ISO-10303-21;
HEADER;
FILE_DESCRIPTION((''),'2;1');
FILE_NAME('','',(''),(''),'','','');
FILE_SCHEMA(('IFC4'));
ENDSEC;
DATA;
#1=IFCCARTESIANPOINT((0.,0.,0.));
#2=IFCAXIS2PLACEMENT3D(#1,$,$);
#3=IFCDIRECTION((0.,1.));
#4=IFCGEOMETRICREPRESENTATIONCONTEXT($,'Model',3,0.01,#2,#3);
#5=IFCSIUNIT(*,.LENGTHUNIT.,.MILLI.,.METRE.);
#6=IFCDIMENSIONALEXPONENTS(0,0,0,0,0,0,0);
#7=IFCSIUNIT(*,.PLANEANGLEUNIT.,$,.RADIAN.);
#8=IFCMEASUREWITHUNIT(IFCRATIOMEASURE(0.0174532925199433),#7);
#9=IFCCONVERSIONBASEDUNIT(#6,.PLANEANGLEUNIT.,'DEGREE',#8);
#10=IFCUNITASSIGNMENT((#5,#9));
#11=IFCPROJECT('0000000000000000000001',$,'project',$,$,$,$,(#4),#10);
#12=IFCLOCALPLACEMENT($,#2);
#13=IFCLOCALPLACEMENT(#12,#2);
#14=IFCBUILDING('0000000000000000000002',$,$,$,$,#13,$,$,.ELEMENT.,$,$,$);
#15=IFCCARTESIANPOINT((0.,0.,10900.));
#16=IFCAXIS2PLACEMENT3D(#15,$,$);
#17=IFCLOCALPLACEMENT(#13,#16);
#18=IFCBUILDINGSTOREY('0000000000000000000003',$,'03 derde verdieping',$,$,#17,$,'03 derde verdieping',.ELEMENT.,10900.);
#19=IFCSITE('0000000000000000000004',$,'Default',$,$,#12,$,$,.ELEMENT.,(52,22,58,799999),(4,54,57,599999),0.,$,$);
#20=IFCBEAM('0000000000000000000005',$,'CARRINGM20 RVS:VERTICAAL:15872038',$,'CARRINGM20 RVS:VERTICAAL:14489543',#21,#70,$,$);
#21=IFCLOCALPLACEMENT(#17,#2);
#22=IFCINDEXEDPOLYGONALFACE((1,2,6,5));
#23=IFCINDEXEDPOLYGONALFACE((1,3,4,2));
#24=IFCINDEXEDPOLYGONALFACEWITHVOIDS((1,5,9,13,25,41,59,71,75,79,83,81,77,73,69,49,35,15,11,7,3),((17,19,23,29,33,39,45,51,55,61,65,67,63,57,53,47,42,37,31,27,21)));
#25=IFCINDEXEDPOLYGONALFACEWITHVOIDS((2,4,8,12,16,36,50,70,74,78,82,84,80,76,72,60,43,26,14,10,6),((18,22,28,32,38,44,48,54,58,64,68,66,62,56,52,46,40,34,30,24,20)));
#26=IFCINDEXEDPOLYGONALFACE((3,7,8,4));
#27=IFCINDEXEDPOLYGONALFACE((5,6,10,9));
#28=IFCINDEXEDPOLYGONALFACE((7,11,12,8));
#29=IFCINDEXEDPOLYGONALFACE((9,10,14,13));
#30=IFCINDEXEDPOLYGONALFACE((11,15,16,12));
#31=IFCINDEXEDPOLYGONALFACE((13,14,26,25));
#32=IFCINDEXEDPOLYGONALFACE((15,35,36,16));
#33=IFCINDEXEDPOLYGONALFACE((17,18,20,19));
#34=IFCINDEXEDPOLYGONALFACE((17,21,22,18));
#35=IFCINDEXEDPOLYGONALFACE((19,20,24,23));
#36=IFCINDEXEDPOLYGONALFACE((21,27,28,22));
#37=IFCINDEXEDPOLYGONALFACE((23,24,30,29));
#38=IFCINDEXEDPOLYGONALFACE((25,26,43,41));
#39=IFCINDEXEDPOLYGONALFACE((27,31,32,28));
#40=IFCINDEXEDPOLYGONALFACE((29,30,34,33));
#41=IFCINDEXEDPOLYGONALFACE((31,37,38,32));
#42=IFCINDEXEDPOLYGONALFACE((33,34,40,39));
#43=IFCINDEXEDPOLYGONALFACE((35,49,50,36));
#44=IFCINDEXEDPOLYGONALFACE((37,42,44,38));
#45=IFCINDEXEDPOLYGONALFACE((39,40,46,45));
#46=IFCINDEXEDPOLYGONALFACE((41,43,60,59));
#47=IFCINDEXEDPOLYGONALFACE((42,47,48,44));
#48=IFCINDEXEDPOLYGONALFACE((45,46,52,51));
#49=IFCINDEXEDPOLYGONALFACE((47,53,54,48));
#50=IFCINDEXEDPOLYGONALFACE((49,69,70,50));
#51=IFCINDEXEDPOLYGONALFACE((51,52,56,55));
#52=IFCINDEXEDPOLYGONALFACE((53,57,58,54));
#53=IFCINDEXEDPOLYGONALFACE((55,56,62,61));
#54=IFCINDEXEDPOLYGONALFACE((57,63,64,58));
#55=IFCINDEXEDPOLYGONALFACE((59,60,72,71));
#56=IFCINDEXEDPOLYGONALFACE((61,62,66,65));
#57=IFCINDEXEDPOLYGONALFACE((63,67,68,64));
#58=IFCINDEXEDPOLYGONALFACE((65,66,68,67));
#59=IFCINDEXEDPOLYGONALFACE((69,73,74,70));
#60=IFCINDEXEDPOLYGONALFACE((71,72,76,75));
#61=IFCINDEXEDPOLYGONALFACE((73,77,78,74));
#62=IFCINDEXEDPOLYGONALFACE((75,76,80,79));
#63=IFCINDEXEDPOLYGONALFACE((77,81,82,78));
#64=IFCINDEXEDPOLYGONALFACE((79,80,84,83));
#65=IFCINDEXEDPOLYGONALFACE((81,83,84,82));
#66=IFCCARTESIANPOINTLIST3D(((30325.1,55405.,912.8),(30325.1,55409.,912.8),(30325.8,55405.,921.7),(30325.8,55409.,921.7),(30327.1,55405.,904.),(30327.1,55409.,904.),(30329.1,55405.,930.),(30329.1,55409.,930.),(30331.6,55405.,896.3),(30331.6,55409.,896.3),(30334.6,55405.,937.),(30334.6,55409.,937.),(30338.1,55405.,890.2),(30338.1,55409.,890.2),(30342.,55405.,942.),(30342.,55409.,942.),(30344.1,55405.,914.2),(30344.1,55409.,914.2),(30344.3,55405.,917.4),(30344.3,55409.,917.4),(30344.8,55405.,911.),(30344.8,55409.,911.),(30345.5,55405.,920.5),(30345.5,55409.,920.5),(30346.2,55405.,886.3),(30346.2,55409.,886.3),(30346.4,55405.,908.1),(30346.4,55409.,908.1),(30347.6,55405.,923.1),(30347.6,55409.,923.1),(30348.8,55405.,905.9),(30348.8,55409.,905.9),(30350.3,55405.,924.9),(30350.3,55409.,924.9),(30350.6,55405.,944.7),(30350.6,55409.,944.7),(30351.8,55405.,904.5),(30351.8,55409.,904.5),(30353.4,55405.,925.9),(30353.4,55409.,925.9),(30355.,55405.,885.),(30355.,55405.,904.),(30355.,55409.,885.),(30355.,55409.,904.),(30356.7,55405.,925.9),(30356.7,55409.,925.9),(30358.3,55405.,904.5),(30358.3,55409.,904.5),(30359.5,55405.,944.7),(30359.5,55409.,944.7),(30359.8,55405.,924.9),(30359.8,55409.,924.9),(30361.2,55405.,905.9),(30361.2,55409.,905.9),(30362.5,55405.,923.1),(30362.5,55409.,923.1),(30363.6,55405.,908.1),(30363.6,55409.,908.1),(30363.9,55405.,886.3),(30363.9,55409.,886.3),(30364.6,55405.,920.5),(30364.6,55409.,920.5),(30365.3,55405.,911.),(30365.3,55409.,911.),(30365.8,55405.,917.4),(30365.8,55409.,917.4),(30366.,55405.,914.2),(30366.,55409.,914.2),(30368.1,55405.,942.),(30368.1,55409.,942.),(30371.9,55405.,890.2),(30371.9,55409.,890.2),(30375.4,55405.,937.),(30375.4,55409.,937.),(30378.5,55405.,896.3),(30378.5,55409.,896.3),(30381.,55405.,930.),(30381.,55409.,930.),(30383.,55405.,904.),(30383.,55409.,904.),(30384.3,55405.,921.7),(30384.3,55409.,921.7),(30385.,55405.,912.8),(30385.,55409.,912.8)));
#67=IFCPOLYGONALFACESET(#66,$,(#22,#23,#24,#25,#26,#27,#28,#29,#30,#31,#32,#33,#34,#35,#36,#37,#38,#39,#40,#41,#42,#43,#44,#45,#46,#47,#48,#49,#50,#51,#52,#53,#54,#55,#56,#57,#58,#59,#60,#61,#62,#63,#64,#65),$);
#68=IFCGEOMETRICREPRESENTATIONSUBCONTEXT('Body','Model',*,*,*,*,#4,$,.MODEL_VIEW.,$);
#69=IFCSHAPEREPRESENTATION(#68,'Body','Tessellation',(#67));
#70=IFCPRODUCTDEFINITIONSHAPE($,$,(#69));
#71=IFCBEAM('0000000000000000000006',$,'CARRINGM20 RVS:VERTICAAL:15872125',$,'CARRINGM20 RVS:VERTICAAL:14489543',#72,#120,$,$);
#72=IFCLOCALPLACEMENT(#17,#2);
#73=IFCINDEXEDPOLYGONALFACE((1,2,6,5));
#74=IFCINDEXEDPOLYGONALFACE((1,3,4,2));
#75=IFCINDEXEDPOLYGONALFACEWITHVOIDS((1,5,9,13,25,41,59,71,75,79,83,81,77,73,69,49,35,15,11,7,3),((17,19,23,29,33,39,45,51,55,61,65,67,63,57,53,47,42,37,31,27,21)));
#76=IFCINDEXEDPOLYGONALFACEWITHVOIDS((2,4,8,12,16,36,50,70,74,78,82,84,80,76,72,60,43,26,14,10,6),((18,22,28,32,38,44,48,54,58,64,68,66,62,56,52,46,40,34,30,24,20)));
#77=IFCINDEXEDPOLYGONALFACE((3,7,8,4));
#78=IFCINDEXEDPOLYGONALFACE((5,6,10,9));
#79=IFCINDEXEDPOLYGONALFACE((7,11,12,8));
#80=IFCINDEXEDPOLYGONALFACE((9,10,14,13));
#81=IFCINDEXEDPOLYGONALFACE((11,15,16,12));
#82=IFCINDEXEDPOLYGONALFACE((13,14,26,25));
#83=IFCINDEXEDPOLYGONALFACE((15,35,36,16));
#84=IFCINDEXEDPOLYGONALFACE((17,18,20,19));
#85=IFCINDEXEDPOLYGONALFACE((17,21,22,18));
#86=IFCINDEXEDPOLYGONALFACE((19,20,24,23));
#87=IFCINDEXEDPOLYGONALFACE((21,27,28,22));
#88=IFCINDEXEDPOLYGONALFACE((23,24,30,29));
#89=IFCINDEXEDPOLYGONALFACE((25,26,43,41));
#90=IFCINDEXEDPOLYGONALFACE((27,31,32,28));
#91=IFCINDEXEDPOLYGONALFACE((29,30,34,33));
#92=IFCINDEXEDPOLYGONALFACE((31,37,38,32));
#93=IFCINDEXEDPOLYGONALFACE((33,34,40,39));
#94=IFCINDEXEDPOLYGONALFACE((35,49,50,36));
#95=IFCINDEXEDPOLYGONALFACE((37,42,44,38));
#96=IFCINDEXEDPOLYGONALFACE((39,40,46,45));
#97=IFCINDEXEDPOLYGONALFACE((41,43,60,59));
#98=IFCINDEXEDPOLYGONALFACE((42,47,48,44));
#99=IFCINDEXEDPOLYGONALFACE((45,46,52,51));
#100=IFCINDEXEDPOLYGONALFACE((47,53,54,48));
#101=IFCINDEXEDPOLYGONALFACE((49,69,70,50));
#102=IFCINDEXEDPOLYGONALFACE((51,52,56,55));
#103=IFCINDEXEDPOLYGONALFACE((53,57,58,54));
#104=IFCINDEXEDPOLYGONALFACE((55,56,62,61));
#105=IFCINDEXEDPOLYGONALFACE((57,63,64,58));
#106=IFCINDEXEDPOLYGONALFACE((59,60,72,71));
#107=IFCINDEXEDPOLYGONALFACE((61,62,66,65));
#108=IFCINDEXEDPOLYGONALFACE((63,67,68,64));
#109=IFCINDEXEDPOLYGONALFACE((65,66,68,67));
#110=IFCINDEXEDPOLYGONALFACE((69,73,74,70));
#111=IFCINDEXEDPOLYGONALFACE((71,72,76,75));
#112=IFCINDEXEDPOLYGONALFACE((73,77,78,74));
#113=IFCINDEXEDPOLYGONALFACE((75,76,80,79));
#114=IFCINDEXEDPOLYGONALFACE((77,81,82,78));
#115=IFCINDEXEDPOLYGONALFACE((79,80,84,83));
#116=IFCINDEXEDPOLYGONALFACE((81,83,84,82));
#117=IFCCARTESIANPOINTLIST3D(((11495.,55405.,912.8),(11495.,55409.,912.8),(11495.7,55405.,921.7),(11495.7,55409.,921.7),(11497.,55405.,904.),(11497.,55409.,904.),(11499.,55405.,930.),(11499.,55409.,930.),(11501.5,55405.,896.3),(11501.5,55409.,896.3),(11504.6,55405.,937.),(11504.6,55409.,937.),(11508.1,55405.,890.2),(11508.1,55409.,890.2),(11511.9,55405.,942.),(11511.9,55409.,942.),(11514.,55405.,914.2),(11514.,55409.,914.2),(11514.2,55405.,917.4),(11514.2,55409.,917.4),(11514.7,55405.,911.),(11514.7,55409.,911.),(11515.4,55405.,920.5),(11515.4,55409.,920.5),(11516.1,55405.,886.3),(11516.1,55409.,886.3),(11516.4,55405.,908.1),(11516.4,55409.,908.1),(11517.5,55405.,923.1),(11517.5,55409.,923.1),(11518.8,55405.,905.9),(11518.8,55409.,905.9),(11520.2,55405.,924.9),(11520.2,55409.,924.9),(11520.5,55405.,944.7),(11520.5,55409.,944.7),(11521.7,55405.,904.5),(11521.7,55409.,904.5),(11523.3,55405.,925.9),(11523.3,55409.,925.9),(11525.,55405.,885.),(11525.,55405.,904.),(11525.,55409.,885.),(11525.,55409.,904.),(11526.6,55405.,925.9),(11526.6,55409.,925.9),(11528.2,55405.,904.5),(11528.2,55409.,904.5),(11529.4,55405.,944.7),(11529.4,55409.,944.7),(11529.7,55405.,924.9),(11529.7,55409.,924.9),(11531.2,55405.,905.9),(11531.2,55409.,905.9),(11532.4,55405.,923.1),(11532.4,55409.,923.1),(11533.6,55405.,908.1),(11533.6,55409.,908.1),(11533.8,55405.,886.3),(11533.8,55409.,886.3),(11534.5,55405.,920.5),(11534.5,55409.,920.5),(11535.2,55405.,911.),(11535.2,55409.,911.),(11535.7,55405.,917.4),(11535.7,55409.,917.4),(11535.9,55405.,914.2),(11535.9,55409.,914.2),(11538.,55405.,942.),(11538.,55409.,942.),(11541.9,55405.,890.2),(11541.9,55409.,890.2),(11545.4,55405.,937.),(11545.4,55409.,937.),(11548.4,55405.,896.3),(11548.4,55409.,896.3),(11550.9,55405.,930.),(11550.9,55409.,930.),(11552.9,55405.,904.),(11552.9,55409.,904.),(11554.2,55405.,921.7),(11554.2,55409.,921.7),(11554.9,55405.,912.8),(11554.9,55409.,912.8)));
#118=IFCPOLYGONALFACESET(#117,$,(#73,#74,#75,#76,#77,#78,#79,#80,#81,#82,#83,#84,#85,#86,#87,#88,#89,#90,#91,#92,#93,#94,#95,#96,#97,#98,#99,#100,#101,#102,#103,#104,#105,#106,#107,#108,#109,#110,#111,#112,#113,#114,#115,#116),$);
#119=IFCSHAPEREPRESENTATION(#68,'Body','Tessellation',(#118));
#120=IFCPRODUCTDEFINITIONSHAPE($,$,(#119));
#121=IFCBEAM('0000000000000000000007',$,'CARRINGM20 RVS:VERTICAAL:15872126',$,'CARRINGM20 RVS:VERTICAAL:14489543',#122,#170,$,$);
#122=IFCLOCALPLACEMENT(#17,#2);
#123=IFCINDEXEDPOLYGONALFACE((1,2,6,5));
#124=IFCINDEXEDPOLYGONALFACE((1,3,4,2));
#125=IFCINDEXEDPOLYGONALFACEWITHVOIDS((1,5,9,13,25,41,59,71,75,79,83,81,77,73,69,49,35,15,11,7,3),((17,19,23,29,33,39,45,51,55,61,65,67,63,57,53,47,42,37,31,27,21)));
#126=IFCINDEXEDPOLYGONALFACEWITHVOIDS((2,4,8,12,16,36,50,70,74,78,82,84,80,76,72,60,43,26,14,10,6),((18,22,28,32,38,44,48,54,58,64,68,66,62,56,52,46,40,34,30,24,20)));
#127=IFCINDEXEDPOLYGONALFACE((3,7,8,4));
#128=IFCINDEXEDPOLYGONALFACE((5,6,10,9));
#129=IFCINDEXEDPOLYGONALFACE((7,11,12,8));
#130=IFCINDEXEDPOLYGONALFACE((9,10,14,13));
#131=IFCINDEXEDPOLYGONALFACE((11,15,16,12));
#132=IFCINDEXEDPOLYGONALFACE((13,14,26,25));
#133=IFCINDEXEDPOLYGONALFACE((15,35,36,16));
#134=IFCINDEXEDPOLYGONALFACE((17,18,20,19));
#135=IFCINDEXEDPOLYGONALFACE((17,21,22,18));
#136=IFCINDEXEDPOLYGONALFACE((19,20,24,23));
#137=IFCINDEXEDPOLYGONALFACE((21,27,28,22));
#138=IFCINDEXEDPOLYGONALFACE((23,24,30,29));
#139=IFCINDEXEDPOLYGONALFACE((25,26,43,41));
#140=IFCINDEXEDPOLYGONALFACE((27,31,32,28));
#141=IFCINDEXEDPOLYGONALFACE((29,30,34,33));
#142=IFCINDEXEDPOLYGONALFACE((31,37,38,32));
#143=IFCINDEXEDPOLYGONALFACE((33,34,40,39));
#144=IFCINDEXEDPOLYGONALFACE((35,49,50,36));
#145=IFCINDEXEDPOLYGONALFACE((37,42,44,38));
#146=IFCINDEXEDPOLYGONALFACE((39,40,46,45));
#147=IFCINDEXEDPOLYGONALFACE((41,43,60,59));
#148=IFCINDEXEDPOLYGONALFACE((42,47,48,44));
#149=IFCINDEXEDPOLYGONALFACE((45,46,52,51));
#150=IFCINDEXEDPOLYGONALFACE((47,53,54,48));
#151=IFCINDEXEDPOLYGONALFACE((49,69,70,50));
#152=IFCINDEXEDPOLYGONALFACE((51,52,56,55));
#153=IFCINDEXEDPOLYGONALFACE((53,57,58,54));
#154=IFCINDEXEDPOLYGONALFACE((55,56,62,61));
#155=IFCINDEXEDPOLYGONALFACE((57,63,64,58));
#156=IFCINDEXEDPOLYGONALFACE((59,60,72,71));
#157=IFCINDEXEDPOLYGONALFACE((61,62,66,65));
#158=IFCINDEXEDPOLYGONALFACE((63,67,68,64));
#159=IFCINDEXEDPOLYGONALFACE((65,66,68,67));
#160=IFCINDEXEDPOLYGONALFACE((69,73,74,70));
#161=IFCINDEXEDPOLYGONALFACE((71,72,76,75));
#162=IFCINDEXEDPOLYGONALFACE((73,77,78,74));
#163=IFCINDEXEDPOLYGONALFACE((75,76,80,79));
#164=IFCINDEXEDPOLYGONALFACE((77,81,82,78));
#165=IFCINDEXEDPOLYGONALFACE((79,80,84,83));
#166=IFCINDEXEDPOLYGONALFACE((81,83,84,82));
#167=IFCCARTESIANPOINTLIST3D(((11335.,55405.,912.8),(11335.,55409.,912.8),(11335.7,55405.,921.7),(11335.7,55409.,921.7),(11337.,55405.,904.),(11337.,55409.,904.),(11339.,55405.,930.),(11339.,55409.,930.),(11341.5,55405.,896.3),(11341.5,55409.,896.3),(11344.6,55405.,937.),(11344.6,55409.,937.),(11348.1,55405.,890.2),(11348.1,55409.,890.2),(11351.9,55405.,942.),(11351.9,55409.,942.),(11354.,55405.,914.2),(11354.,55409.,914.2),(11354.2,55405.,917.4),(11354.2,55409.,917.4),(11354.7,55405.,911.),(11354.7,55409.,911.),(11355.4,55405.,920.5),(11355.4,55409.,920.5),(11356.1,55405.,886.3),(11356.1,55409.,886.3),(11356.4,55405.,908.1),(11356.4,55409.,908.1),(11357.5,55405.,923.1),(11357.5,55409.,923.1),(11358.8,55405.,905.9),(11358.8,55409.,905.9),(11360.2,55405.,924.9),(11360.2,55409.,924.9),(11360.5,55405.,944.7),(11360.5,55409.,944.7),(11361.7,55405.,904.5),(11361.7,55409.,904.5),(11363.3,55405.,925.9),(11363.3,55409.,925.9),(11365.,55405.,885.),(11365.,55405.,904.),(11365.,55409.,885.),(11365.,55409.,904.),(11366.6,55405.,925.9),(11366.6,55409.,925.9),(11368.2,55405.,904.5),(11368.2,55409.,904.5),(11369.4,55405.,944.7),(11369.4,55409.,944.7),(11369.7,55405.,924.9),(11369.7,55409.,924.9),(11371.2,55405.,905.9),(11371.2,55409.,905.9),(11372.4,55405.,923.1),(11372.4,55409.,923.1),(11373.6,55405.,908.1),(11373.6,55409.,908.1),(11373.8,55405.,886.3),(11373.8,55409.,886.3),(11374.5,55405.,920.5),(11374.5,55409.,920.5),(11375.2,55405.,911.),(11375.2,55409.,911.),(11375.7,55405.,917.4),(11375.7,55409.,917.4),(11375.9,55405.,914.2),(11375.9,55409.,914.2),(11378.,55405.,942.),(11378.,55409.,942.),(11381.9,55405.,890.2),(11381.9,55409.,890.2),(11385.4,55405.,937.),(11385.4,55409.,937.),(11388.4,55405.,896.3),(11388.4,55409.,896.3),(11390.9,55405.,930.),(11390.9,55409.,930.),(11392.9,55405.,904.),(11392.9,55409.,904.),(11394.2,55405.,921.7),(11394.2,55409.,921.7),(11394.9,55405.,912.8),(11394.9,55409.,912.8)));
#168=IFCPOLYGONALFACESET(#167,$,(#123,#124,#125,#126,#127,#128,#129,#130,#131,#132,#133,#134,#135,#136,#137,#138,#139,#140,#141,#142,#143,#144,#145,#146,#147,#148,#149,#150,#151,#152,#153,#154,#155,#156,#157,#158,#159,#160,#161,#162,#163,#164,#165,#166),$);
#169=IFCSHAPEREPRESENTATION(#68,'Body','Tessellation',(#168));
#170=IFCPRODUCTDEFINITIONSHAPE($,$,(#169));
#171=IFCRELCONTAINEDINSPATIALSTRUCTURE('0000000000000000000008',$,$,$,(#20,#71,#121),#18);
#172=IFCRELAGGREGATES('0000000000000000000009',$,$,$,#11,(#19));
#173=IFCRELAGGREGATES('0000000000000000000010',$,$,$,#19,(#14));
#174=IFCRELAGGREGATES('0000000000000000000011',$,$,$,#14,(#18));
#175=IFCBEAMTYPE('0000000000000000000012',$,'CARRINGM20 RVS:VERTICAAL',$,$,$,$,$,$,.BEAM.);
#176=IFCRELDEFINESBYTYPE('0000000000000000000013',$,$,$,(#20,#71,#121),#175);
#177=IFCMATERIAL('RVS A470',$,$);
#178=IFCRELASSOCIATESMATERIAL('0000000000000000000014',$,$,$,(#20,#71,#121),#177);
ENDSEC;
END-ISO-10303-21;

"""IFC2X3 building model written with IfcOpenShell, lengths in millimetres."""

from ifc_helpers import new_model, entity, si_unit, converted_unit, direction, frame, origin, origin_2d_with_axis, place, context, subcontext, project, spatial, hollow_circle, extrude, material, type_object, element, save


model = new_model("IFC2X3")

# Units and contexts
model_context = context("Model", 3, precision=0.01, world=origin(), true_north=direction((0.0, 1.0)))
body_context = subcontext(model_context, "Body", "Model", "MODEL_VIEW")
ifc_project = project(units=[si_unit("LENGTHUNIT", "METRE", prefix="MILLI"), converted_unit("PLANEANGLEUNIT", "DEGREE", entity("IfcRatioMeasure", 0.0174532925199433), si_unit("PLANEANGLEUNIT", "RADIAN"), dimensions=[0, 0, 0, 0, 0, 0, 0])], contexts=[model_context])

# Site, building, storey
site_placement = place(None, origin())
site = spatial("IfcSite", under=ifc_project, at=site_placement, Name="Default", CompositionType="ELEMENT", RefLatitude=(52, 22, 58, 799999), RefLongitude=(4, 54, 57, 599999), RefElevation=0.0)
building_placement = place(site_placement, origin())
building = spatial("IfcBuilding", under=site, at=building_placement, CompositionType="ELEMENT")
storey_placement = place(building_placement, frame((0.0, 0.0, 10900.0)))
storey = spatial("IfcBuildingStorey", under=building, at=storey_placement, Name="03 derde verdieping", LongName="03 derde verdieping", CompositionType="ELEMENT", Elevation=10900.0)

# Beams
ifc_material_1 = material(Name="RVS A470")
beam_type_1 = type_object("IfcBeamType", Name="CARRINGM20 RVS:VERTICAAL", PredefinedType="BEAM")
beam_1_placement = place(storey_placement, origin())
element("IfcBeam", 1, at=beam_1_placement, inside=storey, type_object=beam_type_1, material=ifc_material_1, Name="CARRINGM20 RVS:VERTICAAL:15872038", ObjectType="CARRINGM20 RVS:VERTICAAL:14489543", context=body_context, shape_type="SweptSolid", body=[
    extrude(hollow_circle(Radius=30.0, WallThickness=19.0, at=origin_2d_with_axis()), frame((30355.0, 55405.0, 915.0), z_axis=(0.0, 1.0, 0.0), x_axis=(0.0, 0.0, -1.0)), (0.0, 0.0, 1.0), 4.0),
])
beam_2_placement = place(storey_placement, origin())
element("IfcBeam", 2, at=beam_2_placement, inside=storey, type_object=beam_type_1, material=ifc_material_1, Name="CARRINGM20 RVS:VERTICAAL:15872125", ObjectType="CARRINGM20 RVS:VERTICAAL:14489543", context=body_context, shape_type="SweptSolid", body=[
    extrude(hollow_circle(Radius=30.0, WallThickness=19.0, at=origin_2d_with_axis()), frame((11525.0, 55405.0, 915.0), z_axis=(0.0, 1.0, 0.0), x_axis=(0.0, 0.0, -1.0)), (0.0, 0.0, 1.0), 4.0),
])
beam_3_placement = place(storey_placement, origin())
element("IfcBeam", 3, at=beam_3_placement, inside=storey, type_object=beam_type_1, material=ifc_material_1, Name="CARRINGM20 RVS:VERTICAAL:15872126", ObjectType="CARRINGM20 RVS:VERTICAAL:14489543", context=body_context, shape_type="SweptSolid", body=[
    extrude(hollow_circle(Radius=30.0, WallThickness=19.0, at=origin_2d_with_axis()), frame((11365.0, 55405.0, 915.0), z_axis=(0.0, 1.0, 0.0), x_axis=(0.0, 0.0, -1.0)), (0.0, 0.0, 1.0), 4.0),
])

save(model, "model.ifc")
